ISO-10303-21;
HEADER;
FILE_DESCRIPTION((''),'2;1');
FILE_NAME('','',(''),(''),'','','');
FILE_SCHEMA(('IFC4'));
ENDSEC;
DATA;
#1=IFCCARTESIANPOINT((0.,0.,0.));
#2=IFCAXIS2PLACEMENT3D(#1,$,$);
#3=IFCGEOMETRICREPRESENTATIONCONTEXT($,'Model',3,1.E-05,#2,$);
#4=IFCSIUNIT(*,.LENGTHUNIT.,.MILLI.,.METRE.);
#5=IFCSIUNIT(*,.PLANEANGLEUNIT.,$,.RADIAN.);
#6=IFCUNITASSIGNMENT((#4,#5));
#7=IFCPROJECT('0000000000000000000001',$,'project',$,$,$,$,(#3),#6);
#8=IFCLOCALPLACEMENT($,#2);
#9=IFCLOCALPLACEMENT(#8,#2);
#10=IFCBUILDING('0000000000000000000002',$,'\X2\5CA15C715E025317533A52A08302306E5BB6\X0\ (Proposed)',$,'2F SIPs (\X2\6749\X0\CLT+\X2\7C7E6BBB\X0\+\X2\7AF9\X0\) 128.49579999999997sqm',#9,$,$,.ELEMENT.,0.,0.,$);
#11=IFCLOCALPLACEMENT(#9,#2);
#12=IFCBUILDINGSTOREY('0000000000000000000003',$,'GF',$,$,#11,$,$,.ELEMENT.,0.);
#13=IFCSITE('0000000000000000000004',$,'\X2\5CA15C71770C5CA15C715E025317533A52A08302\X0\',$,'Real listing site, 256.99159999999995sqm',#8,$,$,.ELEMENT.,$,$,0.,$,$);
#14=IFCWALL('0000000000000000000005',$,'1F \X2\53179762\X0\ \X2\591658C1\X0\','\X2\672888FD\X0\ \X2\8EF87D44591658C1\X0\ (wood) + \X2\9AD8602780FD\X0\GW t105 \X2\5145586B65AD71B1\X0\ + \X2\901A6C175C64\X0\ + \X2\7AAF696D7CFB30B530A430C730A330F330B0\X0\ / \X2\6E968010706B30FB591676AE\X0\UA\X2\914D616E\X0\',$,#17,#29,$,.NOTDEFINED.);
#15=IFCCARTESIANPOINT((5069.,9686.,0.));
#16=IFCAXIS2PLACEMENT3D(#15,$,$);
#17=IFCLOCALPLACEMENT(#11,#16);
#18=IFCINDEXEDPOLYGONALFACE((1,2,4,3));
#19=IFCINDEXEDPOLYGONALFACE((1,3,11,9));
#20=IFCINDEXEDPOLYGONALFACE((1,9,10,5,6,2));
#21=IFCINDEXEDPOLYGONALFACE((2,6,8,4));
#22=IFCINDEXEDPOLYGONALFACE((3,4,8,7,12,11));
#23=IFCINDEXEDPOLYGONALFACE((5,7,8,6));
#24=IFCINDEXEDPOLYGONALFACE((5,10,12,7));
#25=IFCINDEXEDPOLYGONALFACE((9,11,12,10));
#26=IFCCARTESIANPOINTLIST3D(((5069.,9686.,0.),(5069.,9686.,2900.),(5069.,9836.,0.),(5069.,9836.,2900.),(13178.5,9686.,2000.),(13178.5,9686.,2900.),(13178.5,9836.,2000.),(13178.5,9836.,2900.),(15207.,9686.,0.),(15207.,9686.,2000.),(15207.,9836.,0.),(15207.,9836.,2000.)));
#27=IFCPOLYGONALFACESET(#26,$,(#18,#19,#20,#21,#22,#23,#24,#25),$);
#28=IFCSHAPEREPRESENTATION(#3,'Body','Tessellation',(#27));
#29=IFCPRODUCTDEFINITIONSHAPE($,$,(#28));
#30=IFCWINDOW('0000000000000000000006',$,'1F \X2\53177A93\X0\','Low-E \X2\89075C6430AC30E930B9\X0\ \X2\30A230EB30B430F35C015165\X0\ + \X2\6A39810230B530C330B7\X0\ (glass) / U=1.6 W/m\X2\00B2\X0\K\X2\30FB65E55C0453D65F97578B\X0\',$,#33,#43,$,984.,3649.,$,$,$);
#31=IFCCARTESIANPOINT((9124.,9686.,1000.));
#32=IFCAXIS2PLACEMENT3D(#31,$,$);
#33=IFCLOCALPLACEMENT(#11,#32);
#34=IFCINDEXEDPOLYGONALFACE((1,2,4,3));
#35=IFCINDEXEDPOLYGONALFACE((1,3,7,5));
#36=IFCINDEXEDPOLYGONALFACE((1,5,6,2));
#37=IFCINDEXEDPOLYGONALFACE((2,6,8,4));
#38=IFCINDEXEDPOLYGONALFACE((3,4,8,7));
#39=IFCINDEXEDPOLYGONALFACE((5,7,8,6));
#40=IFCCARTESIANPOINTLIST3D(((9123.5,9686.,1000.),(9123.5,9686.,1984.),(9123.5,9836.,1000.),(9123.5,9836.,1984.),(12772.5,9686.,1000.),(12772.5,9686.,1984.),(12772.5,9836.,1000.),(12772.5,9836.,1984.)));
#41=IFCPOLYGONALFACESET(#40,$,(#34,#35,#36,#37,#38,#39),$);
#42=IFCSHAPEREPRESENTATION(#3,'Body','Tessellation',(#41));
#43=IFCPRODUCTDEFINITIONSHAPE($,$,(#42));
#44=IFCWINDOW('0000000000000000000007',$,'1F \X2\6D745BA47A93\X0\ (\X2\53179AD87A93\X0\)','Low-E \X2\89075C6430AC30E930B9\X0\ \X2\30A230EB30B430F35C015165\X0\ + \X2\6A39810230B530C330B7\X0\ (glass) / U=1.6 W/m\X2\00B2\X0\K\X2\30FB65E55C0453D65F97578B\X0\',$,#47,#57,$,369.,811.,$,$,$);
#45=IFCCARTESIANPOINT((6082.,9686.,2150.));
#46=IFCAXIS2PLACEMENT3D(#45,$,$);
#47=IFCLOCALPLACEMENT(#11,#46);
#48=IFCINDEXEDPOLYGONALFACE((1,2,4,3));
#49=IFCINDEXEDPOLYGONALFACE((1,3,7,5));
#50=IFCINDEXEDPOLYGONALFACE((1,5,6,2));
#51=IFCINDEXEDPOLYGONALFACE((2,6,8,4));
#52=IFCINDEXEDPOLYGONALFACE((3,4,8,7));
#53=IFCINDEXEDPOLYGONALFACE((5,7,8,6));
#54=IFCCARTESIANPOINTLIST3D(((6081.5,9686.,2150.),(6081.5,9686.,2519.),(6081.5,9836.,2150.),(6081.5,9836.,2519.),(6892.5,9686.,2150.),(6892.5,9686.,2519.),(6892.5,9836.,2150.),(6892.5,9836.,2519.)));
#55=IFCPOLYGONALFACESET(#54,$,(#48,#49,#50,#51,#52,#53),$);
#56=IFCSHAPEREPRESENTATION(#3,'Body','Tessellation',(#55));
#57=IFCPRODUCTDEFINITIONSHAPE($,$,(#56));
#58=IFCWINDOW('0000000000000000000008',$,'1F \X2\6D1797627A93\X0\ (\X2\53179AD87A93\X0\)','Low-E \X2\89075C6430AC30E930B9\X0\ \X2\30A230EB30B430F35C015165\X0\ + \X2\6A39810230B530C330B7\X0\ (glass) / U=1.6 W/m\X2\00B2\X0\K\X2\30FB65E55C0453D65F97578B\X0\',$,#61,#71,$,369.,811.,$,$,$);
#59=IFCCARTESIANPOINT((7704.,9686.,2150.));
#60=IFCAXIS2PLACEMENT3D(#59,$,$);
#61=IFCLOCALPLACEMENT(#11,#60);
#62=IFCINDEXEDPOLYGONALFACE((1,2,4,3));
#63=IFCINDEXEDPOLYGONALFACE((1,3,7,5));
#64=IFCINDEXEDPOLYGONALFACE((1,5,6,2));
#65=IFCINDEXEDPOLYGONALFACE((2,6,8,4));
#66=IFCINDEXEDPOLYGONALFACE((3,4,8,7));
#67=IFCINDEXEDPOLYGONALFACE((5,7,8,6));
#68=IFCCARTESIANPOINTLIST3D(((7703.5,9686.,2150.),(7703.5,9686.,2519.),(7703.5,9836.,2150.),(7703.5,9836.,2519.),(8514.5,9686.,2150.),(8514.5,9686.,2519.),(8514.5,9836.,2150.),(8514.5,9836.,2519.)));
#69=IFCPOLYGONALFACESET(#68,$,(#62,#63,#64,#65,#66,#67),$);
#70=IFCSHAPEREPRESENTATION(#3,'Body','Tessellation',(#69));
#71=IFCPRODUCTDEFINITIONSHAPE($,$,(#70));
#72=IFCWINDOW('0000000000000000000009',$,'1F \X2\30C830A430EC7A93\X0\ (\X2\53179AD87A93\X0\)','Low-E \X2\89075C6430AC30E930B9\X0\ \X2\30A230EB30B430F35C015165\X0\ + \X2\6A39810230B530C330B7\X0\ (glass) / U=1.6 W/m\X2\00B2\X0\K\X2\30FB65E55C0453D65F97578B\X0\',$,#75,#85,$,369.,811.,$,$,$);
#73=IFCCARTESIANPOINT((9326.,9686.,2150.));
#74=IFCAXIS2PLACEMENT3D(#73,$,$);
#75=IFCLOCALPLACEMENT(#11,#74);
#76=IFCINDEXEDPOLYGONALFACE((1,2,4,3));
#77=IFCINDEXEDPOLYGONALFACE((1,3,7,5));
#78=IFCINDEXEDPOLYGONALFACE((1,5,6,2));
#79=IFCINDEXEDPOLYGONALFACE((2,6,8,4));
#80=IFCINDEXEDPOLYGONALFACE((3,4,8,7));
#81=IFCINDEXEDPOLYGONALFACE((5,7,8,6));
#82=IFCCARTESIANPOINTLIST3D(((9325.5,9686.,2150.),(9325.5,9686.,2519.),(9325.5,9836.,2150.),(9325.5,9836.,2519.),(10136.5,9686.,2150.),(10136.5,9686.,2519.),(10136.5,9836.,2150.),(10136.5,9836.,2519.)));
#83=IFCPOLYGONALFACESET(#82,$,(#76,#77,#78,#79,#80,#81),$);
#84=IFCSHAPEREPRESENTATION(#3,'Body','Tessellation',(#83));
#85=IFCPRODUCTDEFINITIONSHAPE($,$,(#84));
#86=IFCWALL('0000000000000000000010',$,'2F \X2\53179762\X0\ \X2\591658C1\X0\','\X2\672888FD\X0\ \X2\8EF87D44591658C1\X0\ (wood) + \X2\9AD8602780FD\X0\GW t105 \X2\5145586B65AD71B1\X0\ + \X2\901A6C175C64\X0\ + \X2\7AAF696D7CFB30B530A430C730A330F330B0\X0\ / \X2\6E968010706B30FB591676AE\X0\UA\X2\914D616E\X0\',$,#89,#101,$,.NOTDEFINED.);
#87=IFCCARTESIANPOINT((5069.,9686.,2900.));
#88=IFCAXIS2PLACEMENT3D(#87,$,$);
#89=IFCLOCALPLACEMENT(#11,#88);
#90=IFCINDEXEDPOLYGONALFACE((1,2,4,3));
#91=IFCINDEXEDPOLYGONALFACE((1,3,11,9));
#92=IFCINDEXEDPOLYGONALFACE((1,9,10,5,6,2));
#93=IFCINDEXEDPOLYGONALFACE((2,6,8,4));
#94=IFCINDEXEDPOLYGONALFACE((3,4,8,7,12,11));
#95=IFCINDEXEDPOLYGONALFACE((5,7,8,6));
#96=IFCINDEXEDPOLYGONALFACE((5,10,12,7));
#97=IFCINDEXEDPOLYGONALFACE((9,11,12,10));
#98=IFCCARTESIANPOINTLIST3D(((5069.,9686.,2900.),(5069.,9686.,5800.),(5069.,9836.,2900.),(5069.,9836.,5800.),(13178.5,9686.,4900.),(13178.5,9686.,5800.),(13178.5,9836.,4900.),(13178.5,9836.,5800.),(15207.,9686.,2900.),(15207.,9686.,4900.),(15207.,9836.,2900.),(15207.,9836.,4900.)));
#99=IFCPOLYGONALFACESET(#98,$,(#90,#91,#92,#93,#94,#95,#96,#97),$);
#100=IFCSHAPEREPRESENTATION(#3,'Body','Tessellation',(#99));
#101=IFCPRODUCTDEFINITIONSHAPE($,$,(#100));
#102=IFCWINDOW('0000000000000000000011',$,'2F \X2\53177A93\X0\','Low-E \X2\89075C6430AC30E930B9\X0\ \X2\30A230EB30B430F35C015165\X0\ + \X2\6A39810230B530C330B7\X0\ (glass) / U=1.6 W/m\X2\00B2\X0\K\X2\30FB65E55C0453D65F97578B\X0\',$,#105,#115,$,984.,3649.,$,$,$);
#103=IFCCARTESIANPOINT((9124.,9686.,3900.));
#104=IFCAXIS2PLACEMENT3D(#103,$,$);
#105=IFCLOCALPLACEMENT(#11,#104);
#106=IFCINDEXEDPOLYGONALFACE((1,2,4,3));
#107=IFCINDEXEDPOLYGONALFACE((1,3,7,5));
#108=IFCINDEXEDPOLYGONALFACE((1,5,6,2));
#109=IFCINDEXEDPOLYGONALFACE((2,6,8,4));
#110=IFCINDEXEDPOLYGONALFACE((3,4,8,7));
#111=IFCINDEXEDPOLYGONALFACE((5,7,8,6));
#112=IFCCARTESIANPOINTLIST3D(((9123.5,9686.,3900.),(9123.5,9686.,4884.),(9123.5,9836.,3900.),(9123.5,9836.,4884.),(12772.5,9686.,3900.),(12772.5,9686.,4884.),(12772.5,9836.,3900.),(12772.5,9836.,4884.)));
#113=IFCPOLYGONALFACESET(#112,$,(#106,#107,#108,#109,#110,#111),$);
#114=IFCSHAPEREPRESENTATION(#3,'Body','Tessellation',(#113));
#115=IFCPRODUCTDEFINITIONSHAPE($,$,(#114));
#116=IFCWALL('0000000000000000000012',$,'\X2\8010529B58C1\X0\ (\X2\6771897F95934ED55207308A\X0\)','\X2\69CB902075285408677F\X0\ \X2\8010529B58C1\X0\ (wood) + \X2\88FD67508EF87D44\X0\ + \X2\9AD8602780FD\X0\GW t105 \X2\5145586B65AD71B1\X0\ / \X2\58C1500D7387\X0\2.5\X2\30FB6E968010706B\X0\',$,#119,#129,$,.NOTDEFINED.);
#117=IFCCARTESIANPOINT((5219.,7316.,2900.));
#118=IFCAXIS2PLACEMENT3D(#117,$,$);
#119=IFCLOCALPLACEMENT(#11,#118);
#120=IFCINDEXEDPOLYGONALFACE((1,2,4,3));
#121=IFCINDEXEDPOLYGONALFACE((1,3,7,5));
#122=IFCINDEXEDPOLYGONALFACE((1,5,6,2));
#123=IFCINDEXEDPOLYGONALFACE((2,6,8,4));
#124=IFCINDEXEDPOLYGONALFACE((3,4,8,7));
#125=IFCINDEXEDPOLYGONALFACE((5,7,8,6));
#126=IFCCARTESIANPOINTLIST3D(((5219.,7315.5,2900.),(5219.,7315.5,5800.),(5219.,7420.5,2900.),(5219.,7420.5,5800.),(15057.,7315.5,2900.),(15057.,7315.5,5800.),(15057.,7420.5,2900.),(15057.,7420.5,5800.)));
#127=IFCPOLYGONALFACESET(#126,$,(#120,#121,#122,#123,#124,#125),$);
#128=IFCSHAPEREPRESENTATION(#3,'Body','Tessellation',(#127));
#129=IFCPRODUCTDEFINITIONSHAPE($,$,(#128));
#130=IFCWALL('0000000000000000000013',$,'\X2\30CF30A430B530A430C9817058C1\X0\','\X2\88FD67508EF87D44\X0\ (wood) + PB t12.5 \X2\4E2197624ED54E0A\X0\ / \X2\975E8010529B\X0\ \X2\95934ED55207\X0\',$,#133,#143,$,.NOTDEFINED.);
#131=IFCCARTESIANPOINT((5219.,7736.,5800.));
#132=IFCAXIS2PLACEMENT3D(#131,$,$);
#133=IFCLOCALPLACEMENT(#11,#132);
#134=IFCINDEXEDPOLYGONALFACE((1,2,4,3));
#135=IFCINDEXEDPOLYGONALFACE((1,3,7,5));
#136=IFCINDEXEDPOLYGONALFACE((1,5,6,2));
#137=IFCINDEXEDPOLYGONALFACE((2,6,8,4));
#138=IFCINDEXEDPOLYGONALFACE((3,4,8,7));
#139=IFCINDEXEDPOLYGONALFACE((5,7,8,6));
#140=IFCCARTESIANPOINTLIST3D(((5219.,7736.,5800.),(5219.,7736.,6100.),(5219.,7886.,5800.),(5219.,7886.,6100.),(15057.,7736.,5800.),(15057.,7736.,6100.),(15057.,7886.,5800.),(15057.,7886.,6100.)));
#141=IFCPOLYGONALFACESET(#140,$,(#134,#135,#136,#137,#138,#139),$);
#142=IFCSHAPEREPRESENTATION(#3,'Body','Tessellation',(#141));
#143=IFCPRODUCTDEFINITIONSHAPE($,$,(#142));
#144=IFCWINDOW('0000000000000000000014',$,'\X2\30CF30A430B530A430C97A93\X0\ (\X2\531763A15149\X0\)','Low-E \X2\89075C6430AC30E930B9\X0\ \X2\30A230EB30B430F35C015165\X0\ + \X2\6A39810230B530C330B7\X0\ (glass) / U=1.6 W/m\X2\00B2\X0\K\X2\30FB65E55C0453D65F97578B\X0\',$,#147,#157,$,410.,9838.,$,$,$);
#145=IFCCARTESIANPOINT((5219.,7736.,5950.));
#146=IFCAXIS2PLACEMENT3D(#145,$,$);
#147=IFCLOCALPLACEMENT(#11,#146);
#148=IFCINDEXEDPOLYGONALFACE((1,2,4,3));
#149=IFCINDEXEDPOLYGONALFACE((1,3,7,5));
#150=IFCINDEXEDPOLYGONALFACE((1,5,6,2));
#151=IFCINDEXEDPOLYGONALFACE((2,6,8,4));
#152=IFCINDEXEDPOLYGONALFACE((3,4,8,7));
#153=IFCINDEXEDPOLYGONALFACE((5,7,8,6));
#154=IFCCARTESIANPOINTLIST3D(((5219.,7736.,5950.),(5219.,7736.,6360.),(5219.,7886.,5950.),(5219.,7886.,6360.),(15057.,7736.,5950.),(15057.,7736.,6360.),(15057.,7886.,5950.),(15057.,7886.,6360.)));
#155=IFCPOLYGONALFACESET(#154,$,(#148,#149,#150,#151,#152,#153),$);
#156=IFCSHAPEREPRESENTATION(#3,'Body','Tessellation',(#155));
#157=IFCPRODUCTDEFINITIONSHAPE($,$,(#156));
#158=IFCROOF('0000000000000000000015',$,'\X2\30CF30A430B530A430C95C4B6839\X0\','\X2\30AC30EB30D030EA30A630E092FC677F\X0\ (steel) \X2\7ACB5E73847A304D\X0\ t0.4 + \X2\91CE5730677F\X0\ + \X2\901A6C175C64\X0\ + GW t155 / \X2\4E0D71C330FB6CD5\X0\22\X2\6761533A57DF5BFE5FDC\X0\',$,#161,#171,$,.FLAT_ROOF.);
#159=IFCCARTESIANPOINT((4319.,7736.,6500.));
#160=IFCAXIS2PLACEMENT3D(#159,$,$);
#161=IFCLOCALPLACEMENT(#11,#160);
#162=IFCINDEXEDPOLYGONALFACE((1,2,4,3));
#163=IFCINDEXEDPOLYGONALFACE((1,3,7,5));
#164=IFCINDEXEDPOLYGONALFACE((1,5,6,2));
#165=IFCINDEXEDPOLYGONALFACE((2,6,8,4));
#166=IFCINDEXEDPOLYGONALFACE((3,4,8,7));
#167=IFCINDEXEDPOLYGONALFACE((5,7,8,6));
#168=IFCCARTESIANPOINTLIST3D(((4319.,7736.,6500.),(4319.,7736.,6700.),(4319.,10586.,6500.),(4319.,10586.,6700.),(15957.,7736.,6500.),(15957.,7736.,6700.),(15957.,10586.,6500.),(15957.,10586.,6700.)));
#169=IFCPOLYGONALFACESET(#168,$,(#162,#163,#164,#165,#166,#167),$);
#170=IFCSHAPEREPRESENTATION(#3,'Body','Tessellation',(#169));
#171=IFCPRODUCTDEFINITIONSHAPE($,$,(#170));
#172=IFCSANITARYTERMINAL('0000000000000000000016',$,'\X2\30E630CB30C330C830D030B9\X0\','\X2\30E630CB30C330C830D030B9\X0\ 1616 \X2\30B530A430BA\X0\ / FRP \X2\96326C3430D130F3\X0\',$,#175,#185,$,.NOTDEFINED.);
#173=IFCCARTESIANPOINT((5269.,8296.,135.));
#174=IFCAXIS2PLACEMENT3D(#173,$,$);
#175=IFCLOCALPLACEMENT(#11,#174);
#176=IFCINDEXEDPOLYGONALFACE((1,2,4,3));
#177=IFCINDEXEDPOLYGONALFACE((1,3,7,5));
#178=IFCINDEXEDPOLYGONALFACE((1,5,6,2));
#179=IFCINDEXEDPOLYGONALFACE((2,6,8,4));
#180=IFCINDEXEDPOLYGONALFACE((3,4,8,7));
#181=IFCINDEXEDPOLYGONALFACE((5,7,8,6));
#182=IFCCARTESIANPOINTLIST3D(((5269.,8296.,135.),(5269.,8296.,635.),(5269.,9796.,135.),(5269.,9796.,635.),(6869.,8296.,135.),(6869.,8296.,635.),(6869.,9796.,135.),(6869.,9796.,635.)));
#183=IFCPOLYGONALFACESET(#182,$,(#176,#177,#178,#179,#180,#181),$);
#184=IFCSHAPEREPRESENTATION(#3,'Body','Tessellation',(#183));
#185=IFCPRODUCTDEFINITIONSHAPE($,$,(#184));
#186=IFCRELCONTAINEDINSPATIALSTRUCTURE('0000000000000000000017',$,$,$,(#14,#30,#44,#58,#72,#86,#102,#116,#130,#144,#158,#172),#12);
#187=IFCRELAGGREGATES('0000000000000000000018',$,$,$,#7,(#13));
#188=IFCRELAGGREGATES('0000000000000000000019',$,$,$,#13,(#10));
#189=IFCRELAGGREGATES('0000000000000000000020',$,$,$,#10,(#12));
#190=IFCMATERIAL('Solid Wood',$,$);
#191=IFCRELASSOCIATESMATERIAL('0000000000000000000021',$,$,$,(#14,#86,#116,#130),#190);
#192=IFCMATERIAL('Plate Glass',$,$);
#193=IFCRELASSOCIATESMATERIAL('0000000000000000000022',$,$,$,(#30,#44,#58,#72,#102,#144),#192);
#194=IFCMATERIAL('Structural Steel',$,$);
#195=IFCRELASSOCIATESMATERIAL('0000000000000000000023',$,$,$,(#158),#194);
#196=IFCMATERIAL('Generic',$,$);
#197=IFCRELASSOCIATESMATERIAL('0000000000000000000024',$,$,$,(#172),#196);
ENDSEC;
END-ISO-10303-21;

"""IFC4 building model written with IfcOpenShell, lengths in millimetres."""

from ifc_helpers import new_model, si_unit, frame, frame_2d, origin, place, context, project, spatial, rectangle, extrude, material, element, fill, save


model = new_model("IFC4")

# Units and contexts
model_context = context("Model", 3, precision=1e-05, world=origin())
ifc_project = project(units=[si_unit("LENGTHUNIT", "METRE", prefix="MILLI"), si_unit("PLANEANGLEUNIT", "RADIAN")], contexts=[model_context])

# Site, building, storey
site_placement = place(None, origin())
site = spatial("IfcSite", under=ifc_project, at=site_placement, Name="岡山県岡山市北区加茂", ObjectType="Real listing site, 256.99159999999995sqm", CompositionType="ELEMENT", RefElevation=0.0)
building_placement = place(site_placement, origin())
building = spatial("IfcBuilding", under=site, at=building_placement, Name="岡山市北区加茂の家 (Proposed)", ObjectType="2F SIPs (杉CLT+籾殻+竹) 128.49579999999997sqm", CompositionType="ELEMENT", ElevationOfRefHeight=0.0, ElevationOfTerrain=0.0)
storey_placement = place(building_placement, origin())
storey = spatial("IfcBuildingStorey", under=building, at=storey_placement, Name="GF", CompositionType="ELEMENT", Elevation=0.0)

# Wall, openings, windows
ifc_material_1 = material(Name="Solid Wood")
wall_1_placement = place(storey_placement, frame((5069.0, 9686.0, 0.0)))
wall_1 = element("IfcWall", 1, at=wall_1_placement, inside=storey, material=ifc_material_1, Name="1F 北面 外壁", Description="木製 軸組外壁 (wood) + 高性能GW t105 充填断熱 + 通気層 + 窯業系サイディング / 準耐火・外皮UA配慮", PredefinedType="NOTDEFINED", context=model_context, shape_type="SweptSolid", body=[
    extrude(rectangle(XDim=10138.0, YDim=150.0, at=frame_2d((5069.0, 75.0))), frame((5069.0, 9686.0, 0.0)), (0.0, 0.0, 1.0), 2900.0),
])
opening_1_placement = place(storey_placement, frame((9124.0, 9686.0, 1000.0)))
opening_1 = element("IfcOpeningElement", 2, at=opening_1_placement, cuts=wall_1, PredefinedType="NOTDEFINED", context=model_context, shape_type="SweptSolid", body=[
    extrude(rectangle(XDim=3649.0, YDim=150.0, at=frame_2d((1824.0, 75.0))), frame((9124.0, 9686.0, 1000.0)), (0.0, 0.0, 1.0), 984.0),
])
opening_2_placement = place(storey_placement, frame((6082.0, 9686.0, 2150.0)))
opening_2 = element("IfcOpeningElement", 3, at=opening_2_placement, cuts=wall_1, PredefinedType="NOTDEFINED", context=model_context, shape_type="SweptSolid", body=[
    extrude(rectangle(XDim=811.0, YDim=150.0, at=frame_2d((405.0, 75.0))), frame((6082.0, 9686.0, 2150.0)), (0.0, 0.0, 1.0), 369.0),
])
opening_3_placement = place(storey_placement, frame((7704.0, 9686.0, 2150.0)))
opening_3 = element("IfcOpeningElement", 4, at=opening_3_placement, cuts=wall_1, PredefinedType="NOTDEFINED", context=model_context, shape_type="SweptSolid", body=[
    extrude(rectangle(XDim=811.0, YDim=150.0, at=frame_2d((405.0, 75.0))), frame((7704.0, 9686.0, 2150.0)), (0.0, 0.0, 1.0), 369.0),
])
opening_4_placement = place(storey_placement, frame((9326.0, 9686.0, 2150.0)))
opening_4 = element("IfcOpeningElement", 5, at=opening_4_placement, cuts=wall_1, PredefinedType="NOTDEFINED", context=model_context, shape_type="SweptSolid", body=[
    extrude(rectangle(XDim=811.0, YDim=150.0, at=frame_2d((405.0, 75.0))), frame((9326.0, 9686.0, 2150.0)), (0.0, 0.0, 1.0), 369.0),
])
ifc_material_2 = material(Name="Plate Glass")
window_1_placement = place(storey_placement, frame((9124.0, 9686.0, 1000.0)))
window_1 = element("IfcWindow", 6, at=window_1_placement, inside=storey, material=ifc_material_2, Name="1F 北窓", Description="Low-E 複層ガラス アルゴン封入 + 樹脂サッシ (glass) / U=1.6 W/m²K・日射取得型", OverallHeight=984.0, OverallWidth=3649.0, context=model_context, shape_type="SweptSolid", body=[
    extrude(rectangle(XDim=3649.0, YDim=150.0, at=frame_2d((1824.0, 75.0))), frame((9124.0, 9686.0, 1000.0)), (0.0, 0.0, 1.0), 984.0),
])
fill(opening_1, window_1)
window_2_placement = place(storey_placement, frame((6082.0, 9686.0, 2150.0)))
window_2 = element("IfcWindow", 7, at=window_2_placement, inside=storey, material=ifc_material_2, Name="1F 浴室窓 (北高窓)", Description="Low-E 複層ガラス アルゴン封入 + 樹脂サッシ (glass) / U=1.6 W/m²K・日射取得型", OverallHeight=369.0, OverallWidth=811.0, context=model_context, shape_type="SweptSolid", body=[
    extrude(rectangle(XDim=811.0, YDim=150.0, at=frame_2d((405.0, 75.0))), frame((6082.0, 9686.0, 2150.0)), (0.0, 0.0, 1.0), 369.0),
])
fill(opening_2, window_2)
window_3_placement = place(storey_placement, frame((7704.0, 9686.0, 2150.0)))
window_3 = element("IfcWindow", 8, at=window_3_placement, inside=storey, material=ifc_material_2, Name="1F 洗面窓 (北高窓)", Description="Low-E 複層ガラス アルゴン封入 + 樹脂サッシ (glass) / U=1.6 W/m²K・日射取得型", OverallHeight=369.0, OverallWidth=811.0, context=model_context, shape_type="SweptSolid", body=[
    extrude(rectangle(XDim=811.0, YDim=150.0, at=frame_2d((405.0, 75.0))), frame((7704.0, 9686.0, 2150.0)), (0.0, 0.0, 1.0), 369.0),
])
fill(opening_3, window_3)
window_4_placement = place(storey_placement, frame((9326.0, 9686.0, 2150.0)))
window_4 = element("IfcWindow", 9, at=window_4_placement, inside=storey, material=ifc_material_2, Name="1F トイレ窓 (北高窓)", Description="Low-E 複層ガラス アルゴン封入 + 樹脂サッシ (glass) / U=1.6 W/m²K・日射取得型", OverallHeight=369.0, OverallWidth=811.0, context=model_context, shape_type="SweptSolid", body=[
    extrude(rectangle(XDim=811.0, YDim=150.0, at=frame_2d((405.0, 75.0))), frame((9326.0, 9686.0, 2150.0)), (0.0, 0.0, 1.0), 369.0),
])
fill(opening_4, window_4)

# Wall, opening, window
wall_2_placement = place(storey_placement, frame((5069.0, 9686.0, 2900.0)))
wall_2 = element("IfcWall", 10, at=wall_2_placement, inside=storey, material=ifc_material_1, Name="2F 北面 外壁", Description="木製 軸組外壁 (wood) + 高性能GW t105 充填断熱 + 通気層 + 窯業系サイディング / 準耐火・外皮UA配慮", PredefinedType="NOTDEFINED", context=model_context, shape_type="SweptSolid", body=[
    extrude(rectangle(XDim=10138.0, YDim=150.0, at=frame_2d((5069.0, 75.0))), frame((5069.0, 9686.0, 2900.0)), (0.0, 0.0, 1.0), 2900.0),
])
opening_5_placement = place(storey_placement, frame((9124.0, 9686.0, 3900.0)))
opening_5 = element("IfcOpeningElement", 11, at=opening_5_placement, cuts=wall_2, PredefinedType="NOTDEFINED", context=model_context, shape_type="SweptSolid", body=[
    extrude(rectangle(XDim=3649.0, YDim=150.0, at=frame_2d((1824.0, 75.0))), frame((9124.0, 9686.0, 3900.0)), (0.0, 0.0, 1.0), 984.0),
])
window_5_placement = place(storey_placement, frame((9124.0, 9686.0, 3900.0)))
window_5 = element("IfcWindow", 12, at=window_5_placement, inside=storey, material=ifc_material_2, Name="2F 北窓", Description="Low-E 複層ガラス アルゴン封入 + 樹脂サッシ (glass) / U=1.6 W/m²K・日射取得型", OverallHeight=984.0, OverallWidth=3649.0, context=model_context, shape_type="SweptSolid", body=[
    extrude(rectangle(XDim=3649.0, YDim=150.0, at=frame_2d((1824.0, 75.0))), frame((9124.0, 9686.0, 3900.0)), (0.0, 0.0, 1.0), 984.0),
])
fill(opening_5, window_5)

# Wall
wall_3_placement = place(storey_placement, frame((5219.0, 7316.0, 2900.0)))
element("IfcWall", 13, at=wall_3_placement, inside=storey, material=ifc_material_1, Name="耐力壁 (東西間仕切り)", Description="構造用合板 耐力壁 (wood) + 製材軸組 + 高性能GW t105 充填断熱 / 壁倍率2.5・準耐火", PredefinedType="NOTDEFINED", context=model_context, shape_type="SweptSolid", body=[
    extrude(rectangle(XDim=9838.0, YDim=105.0, at=frame_2d((4919.0, 52.0))), frame((5219.0, 7316.0, 2900.0)), (0.0, 0.0, 1.0), 2900.0),
])

# Wall, opening, window
wall_4_placement = place(storey_placement, frame((5219.0, 7736.0, 5800.0)))
wall_4 = element("IfcWall", 14, at=wall_4_placement, inside=storey, material=ifc_material_1, Name="ハイサイド腰壁", Description="製材軸組 (wood) + PB t12.5 両面仕上 / 非耐力 間仕切", PredefinedType="NOTDEFINED", context=model_context, shape_type="SweptSolid", body=[
    extrude(rectangle(XDim=9838.0, YDim=150.0, at=frame_2d((4919.0, 75.0))), frame((5219.0, 7736.0, 5800.0)), (0.0, 0.0, 1.0), 700.0),
])
opening_6_placement = place(storey_placement, frame((5219.0, 7736.0, 5950.0)))
opening_6 = element("IfcOpeningElement", 15, at=opening_6_placement, cuts=wall_4, PredefinedType="NOTDEFINED", context=model_context, shape_type="SweptSolid", body=[
    extrude(rectangle(XDim=9838.0, YDim=150.0, at=frame_2d((4919.0, 75.0))), frame((5219.0, 7736.0, 5950.0)), (0.0, 0.0, 1.0), 410.0),
])
window_6_placement = place(storey_placement, frame((5219.0, 7736.0, 5950.0)))
window_6 = element("IfcWindow", 16, at=window_6_placement, inside=storey, material=ifc_material_2, Name="ハイサイド窓 (北採光)", Description="Low-E 複層ガラス アルゴン封入 + 樹脂サッシ (glass) / U=1.6 W/m²K・日射取得型", OverallHeight=410.0, OverallWidth=9838.0, context=model_context, shape_type="SweptSolid", body=[
    extrude(rectangle(XDim=9838.0, YDim=150.0, at=frame_2d((4919.0, 75.0))), frame((5219.0, 7736.0, 5950.0)), (0.0, 0.0, 1.0), 410.0),
])
fill(opening_6, window_6)

# Roof
ifc_material_3 = material(Name="Structural Steel")
roof_placement = place(storey_placement, frame((4319.0, 7736.0, 6500.0)))
element("IfcRoof", 17, at=roof_placement, inside=storey, material=ifc_material_3, Name="ハイサイド屋根", Description="ガルバリウム鋼板 (steel) 立平葺き t0.4 + 野地板 + 通気層 + GW t155 / 不燃・法22条区域対応", PredefinedType="FLAT_ROOF", context=model_context, shape_type="SweptSolid", body=[
    extrude(rectangle(XDim=11638.0, YDim=2850.0, at=frame_2d((5819.0, 1425.0))), frame((4319.0, 7736.0, 6500.0)), (0.0, 0.0, 1.0), 200.0),
])

# Sanitary terminal
ifc_material_4 = material(Name="Generic")
sanitary_terminal_placement = place(storey_placement, frame((5269.0, 8296.0, 135.0)))
element("IfcSanitaryTerminal", 18, at=sanitary_terminal_placement, inside=storey, material=ifc_material_4, Name="ユニットバス", Description="ユニットバス 1616 サイズ / FRP 防水パン", PredefinedType="NOTDEFINED", context=model_context, shape_type="SweptSolid", body=[
    extrude(rectangle(XDim=1600.0, YDim=1500.0, at=frame_2d((800.0, 750.0))), frame((5269.0, 8296.0, 135.0)), (0.0, 0.0, 1.0), 500.0),
])

save(model, "model.ifc")
